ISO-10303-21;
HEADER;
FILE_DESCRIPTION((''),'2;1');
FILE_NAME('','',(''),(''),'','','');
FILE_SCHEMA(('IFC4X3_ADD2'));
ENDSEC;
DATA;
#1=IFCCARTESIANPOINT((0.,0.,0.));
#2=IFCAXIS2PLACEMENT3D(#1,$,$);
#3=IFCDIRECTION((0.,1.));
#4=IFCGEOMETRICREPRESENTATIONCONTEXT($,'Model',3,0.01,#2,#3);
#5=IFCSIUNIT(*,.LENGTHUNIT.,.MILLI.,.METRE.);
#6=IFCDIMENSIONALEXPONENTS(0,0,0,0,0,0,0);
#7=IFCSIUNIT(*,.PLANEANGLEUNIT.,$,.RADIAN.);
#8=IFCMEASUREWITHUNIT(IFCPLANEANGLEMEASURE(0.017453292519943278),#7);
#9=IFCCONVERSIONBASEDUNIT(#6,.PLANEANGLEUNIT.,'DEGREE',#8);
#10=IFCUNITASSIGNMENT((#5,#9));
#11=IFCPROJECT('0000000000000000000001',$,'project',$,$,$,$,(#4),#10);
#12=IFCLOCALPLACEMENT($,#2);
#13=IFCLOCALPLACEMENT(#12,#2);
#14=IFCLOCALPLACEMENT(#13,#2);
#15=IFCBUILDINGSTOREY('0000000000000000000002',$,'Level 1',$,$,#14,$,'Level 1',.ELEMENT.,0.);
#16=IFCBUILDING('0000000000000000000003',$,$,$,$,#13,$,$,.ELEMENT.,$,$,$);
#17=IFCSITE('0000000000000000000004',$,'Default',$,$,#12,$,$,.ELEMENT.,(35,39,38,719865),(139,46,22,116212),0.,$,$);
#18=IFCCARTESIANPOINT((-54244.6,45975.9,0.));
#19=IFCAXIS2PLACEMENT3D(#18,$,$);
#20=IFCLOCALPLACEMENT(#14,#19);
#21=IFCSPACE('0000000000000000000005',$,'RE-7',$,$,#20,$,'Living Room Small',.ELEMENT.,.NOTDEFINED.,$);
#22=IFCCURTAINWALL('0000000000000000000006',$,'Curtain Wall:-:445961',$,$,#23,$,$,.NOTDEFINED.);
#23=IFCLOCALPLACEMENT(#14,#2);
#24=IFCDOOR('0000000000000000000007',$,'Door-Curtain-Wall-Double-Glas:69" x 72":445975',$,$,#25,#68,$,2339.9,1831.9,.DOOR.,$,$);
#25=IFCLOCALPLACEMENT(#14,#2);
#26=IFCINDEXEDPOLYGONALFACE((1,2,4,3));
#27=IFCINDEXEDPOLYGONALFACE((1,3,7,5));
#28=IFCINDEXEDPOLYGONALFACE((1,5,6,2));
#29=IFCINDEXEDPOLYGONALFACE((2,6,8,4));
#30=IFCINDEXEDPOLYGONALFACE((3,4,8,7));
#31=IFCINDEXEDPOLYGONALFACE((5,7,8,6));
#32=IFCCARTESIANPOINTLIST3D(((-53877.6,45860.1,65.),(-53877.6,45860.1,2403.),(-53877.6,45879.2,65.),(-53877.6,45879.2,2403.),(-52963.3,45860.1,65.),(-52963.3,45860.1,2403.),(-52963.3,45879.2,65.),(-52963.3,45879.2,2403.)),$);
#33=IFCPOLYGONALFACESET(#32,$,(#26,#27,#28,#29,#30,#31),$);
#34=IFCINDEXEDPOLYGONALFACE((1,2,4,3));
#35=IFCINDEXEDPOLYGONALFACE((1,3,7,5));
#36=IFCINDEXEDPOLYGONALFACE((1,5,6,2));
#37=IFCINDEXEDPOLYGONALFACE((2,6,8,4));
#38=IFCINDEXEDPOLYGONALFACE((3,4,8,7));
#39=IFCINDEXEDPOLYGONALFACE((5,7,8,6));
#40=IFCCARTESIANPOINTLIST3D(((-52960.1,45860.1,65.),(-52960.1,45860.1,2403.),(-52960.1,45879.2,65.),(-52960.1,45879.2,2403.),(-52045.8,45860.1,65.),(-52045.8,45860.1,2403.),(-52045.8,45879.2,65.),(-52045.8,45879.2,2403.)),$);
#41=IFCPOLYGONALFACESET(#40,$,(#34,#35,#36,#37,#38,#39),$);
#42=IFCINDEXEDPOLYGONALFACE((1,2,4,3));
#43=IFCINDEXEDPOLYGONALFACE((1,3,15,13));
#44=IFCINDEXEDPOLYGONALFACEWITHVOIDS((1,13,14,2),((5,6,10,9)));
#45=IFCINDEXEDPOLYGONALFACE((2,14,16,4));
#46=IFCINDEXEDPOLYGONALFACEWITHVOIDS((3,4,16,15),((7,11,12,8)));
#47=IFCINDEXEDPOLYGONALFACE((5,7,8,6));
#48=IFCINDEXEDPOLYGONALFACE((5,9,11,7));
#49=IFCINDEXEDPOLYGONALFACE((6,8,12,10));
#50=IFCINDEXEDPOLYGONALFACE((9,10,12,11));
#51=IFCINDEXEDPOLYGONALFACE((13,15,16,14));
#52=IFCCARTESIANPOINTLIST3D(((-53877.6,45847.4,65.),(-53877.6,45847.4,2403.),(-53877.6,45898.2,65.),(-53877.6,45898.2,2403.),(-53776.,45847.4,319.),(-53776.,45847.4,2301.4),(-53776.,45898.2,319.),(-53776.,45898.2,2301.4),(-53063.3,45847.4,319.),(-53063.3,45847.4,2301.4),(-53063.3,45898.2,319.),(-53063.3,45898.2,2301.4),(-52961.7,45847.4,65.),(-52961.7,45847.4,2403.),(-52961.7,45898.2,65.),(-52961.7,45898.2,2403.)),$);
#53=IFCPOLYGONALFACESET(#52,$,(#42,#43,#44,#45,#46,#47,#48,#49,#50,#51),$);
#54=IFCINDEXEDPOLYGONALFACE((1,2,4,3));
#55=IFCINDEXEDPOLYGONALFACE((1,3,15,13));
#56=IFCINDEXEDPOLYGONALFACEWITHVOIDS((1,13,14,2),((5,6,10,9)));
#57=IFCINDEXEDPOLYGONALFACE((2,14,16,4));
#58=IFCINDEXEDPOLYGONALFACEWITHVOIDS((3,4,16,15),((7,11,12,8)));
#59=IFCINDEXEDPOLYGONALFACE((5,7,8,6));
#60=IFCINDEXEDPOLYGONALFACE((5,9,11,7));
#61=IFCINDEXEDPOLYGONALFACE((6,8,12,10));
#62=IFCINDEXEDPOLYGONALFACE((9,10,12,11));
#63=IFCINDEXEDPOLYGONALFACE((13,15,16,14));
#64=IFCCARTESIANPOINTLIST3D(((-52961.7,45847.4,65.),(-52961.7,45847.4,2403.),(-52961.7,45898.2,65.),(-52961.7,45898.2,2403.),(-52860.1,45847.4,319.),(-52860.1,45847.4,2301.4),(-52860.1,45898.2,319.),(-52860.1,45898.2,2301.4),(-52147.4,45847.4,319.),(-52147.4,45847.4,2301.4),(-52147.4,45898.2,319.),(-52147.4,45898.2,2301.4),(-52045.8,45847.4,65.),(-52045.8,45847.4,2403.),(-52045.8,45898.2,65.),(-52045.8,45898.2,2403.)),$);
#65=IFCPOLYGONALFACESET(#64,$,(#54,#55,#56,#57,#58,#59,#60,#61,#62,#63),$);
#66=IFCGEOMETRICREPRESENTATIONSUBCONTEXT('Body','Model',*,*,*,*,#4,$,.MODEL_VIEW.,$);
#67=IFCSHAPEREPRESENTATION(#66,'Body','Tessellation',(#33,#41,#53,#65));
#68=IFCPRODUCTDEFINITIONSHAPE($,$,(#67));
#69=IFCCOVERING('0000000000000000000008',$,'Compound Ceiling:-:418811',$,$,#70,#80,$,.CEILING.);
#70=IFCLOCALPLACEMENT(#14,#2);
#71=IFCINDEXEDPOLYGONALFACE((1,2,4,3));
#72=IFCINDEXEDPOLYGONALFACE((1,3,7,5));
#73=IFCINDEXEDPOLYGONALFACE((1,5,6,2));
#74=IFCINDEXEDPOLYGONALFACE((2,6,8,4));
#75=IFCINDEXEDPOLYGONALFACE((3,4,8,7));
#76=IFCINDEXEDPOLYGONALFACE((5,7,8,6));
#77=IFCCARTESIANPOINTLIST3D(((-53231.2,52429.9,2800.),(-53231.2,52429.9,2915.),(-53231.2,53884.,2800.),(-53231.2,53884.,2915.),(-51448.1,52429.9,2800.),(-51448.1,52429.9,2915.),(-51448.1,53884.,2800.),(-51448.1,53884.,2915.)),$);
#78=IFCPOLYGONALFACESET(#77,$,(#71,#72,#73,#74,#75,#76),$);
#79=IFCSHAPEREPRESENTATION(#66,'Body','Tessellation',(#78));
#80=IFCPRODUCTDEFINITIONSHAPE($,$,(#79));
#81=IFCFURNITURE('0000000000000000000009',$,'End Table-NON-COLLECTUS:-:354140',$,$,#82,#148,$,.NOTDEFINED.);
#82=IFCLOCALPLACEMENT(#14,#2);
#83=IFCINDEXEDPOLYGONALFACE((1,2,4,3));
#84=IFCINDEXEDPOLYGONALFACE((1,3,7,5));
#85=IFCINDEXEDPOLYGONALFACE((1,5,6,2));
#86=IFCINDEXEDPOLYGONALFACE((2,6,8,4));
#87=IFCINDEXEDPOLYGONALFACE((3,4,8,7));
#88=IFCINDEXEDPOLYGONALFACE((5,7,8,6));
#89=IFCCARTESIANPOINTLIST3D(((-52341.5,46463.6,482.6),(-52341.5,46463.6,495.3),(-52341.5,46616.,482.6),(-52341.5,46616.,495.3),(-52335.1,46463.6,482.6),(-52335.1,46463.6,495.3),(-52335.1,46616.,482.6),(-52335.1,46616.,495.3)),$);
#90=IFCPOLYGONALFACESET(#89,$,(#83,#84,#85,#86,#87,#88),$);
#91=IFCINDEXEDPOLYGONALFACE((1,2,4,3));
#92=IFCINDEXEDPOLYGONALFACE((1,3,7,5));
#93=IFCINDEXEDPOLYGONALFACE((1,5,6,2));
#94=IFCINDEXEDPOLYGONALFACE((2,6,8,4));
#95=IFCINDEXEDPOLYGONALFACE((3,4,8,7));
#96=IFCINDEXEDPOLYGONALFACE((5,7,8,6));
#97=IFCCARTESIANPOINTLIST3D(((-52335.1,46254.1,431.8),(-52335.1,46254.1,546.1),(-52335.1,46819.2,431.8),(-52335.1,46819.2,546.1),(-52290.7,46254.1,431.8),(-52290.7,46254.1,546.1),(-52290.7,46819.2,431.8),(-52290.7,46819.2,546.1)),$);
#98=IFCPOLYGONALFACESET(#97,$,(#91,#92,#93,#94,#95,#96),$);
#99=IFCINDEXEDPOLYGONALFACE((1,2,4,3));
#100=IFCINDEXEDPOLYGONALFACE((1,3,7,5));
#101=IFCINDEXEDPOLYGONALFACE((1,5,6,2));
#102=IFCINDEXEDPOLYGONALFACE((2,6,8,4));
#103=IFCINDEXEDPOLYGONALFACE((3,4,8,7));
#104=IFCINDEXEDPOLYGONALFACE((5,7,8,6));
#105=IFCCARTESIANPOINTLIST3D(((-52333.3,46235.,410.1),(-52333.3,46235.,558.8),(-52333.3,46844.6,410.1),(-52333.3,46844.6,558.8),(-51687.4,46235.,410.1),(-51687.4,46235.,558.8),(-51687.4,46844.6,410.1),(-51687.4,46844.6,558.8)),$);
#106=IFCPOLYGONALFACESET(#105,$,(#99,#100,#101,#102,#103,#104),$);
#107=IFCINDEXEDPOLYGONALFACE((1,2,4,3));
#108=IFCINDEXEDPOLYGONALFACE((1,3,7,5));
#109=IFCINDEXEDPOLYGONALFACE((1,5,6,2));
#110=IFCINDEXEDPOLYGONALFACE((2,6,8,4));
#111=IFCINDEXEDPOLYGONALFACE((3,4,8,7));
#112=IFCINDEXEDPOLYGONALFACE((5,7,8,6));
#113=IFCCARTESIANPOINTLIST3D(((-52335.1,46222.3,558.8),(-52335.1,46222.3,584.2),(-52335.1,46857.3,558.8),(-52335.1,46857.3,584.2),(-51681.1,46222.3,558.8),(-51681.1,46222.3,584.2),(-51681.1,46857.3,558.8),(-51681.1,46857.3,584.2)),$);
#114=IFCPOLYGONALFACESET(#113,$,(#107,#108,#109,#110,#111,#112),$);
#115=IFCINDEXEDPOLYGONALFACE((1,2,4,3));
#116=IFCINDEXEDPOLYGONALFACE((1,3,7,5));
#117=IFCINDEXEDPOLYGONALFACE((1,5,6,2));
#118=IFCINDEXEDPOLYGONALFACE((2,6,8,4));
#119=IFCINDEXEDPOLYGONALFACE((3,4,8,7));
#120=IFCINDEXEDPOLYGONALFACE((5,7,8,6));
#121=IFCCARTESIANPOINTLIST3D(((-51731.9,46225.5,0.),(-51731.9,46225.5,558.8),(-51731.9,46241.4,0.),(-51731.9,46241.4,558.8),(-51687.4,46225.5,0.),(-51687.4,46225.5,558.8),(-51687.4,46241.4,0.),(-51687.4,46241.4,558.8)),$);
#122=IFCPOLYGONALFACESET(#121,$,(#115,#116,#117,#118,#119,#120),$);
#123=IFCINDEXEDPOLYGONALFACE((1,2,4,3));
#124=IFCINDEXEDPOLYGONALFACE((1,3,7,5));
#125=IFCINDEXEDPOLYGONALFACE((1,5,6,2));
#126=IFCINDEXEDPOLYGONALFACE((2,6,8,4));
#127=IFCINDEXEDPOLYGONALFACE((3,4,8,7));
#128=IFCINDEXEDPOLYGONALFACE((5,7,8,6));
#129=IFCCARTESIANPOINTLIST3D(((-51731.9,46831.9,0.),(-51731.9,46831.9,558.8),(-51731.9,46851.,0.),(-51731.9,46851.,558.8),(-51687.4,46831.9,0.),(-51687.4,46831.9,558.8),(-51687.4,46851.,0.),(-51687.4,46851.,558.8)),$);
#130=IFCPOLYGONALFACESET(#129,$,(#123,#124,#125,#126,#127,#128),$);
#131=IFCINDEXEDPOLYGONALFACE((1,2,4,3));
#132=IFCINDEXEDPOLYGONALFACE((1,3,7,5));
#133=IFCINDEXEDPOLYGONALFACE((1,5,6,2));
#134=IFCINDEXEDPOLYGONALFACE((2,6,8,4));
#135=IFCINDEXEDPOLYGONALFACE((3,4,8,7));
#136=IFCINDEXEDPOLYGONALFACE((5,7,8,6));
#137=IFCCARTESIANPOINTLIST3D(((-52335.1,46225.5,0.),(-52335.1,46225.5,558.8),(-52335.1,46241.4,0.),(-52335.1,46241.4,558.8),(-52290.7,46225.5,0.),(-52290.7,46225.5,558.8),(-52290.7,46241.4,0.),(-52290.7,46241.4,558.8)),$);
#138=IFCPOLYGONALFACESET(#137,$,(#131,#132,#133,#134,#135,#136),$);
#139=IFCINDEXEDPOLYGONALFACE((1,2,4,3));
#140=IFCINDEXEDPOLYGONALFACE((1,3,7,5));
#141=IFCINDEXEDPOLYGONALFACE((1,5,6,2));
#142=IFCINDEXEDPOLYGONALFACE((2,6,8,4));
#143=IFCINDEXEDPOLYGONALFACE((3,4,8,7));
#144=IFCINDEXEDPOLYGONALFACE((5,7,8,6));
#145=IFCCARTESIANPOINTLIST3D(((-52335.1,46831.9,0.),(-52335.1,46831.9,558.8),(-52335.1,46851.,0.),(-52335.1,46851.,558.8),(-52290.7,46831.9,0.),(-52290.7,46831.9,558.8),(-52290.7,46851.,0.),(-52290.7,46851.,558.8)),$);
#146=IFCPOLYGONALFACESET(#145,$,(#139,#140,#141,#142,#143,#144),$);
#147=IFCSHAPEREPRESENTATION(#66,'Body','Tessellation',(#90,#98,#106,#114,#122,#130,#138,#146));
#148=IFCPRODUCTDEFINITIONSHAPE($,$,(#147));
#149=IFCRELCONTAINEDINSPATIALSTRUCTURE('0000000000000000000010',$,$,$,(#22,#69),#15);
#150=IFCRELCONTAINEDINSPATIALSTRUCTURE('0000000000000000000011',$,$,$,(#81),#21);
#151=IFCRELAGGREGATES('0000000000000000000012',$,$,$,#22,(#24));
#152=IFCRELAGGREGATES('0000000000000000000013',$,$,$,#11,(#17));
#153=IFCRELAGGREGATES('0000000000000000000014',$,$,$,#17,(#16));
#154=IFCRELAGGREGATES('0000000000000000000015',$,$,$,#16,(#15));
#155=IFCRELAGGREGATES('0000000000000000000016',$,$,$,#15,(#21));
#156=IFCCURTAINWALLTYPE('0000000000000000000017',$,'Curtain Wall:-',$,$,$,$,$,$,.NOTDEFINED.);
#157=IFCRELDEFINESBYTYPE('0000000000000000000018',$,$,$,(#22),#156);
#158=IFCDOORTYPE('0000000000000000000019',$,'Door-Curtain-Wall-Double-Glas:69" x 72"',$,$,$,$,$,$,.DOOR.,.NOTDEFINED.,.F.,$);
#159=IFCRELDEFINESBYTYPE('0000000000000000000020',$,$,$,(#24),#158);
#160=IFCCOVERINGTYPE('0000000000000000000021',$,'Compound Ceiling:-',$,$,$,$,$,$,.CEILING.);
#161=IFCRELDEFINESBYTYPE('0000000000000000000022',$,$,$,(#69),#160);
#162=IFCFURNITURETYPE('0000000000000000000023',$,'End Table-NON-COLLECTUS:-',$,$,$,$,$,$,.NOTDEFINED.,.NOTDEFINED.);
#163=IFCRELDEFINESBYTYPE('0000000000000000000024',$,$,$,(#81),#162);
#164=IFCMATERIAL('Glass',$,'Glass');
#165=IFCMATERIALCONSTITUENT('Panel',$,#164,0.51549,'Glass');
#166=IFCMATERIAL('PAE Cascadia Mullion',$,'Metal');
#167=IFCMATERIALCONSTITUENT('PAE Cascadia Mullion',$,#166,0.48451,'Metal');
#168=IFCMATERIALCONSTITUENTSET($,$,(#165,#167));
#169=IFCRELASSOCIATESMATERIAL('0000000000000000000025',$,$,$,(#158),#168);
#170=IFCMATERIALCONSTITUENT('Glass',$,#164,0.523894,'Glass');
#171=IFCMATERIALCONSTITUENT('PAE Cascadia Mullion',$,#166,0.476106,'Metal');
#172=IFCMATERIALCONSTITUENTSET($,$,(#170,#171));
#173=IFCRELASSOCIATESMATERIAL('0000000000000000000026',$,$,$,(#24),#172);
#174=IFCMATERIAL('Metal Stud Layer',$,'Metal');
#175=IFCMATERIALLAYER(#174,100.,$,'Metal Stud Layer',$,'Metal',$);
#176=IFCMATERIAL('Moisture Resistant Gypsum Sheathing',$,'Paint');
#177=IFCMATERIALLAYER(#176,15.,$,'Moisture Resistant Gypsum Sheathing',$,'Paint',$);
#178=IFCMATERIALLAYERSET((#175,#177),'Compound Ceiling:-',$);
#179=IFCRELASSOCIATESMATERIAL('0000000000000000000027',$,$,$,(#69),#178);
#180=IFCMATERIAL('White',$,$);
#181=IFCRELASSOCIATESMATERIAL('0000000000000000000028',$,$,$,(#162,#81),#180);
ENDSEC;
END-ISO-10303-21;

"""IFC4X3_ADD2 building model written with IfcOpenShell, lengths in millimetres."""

from ifc_helpers import new_model, entity, si_unit, converted_unit, direction, frame, frame_2d, origin, origin_2d_with_axis, place, context, subcontext, project, spatial, polyline, rectangle, outline, extrude, source, transform, mapped, material, layer, layer_set, layer_usage, constituent, constituent_set, type_object, type_shapes, element, aggregate, save


model = new_model("IFC4X3_ADD2")

# Units and contexts
model_context = context("Model", 3, precision=0.01, world=origin(), true_north=direction((0.0, 1.0)))
body_context = subcontext(model_context, "Body", "Model", "MODEL_VIEW")
ifc_project = project(units=[si_unit("LENGTHUNIT", "METRE", prefix="MILLI"), converted_unit("PLANEANGLEUNIT", "DEGREE", entity("IfcPlaneAngleMeasure", 0.017453292519943278), si_unit("PLANEANGLEUNIT", "RADIAN"), dimensions=[0, 0, 0, 0, 0, 0, 0])], contexts=[model_context])

# Site, building, storey
site_placement = place(None, origin())
site = spatial("IfcSite", under=ifc_project, at=site_placement, Name="Default", CompositionType="ELEMENT", RefLatitude=(35, 39, 38, 719865), RefLongitude=(139, 46, 22, 116212), RefElevation=0.0)
building_placement = place(site_placement, origin())
building = spatial("IfcBuilding", under=site, at=building_placement, CompositionType="ELEMENT")
storey_placement = place(building_placement, origin())
storey = spatial("IfcBuildingStorey", under=building, at=storey_placement, Name="Level 1", LongName="Level 1", CompositionType="ELEMENT", Elevation=0.0)

# Curtain wall
curtain_wall_type = type_object("IfcCurtainWallType", Name="Curtain Wall:-", PredefinedType="NOTDEFINED")
curtain_wall_placement = place(storey_placement, origin())
curtain_wall = element("IfcCurtainWall", 1, at=curtain_wall_placement, inside=storey, type_object=curtain_wall_type, Name="Curtain Wall:-:445961", PredefinedType="NOTDEFINED")

# Shared definitions
ifc_material_1 = material(Name="Glass", Category="Glass")

# Shared definitions
ifc_material_2 = material(Name="Metal Stud Layer", Category="Metal")

# Door
ifc_constituent_1 = constituent(ifc_material_1, Name="Glass", Category="Glass", fraction=0.523894)
ifc_material_3 = material(Name="PAE Cascadia Mullion", Category="Metal")
ifc_constituent_2 = constituent(ifc_material_3, Name="PAE Cascadia Mullion", Category="Metal", fraction=0.476106)
ifc_constituent_set_1 = constituent_set(constituents=[ifc_constituent_1, ifc_constituent_2])
ifc_constituent_3 = constituent(ifc_material_1, Name="Panel", Category="Glass", fraction=0.51549)
ifc_constituent_4 = constituent(ifc_material_3, Name="PAE Cascadia Mullion", Category="Metal", fraction=0.48451)
ifc_constituent_set_2 = constituent_set(constituents=[ifc_constituent_3, ifc_constituent_4])
door_type_1 = type_object("IfcDoorType", Name="Door-Curtain-Wall-Double-Glas:69\" x 72\"", OperationType="NOTDEFINED", ParameterTakesPrecedence=False, PredefinedType="DOOR", material=ifc_constituent_set_2)
shared_shape_1 = source(origin(), body_context, "Body", "SweptSolid", [
    extrude(rectangle(XDim=19.1, YDim=914.4, at=frame_2d((0.0, 0.0), x_axis=(1.0, 0.0))), frame((458.7, 41.3, 0.0), z_axis=(0.0, 0.0, 1.0), x_axis=(0.0, 1.0, 0.0)), (0.0, 0.0, 1.0), 2338.0),
    extrude(rectangle(XDim=19.1, YDim=914.3, at=frame_2d((0.0, 0.0), x_axis=(1.0, 0.0))), frame((-458.8, 41.3, 0.0), z_axis=(0.0, 0.0, 1.0), x_axis=(0.0, 1.0, 0.0)), (0.0, 0.0, 1.0), 2338.0),
    extrude(outline(polyline([(-458.0, -1169.0), (458.0, -1169.0), (458.0, 1169.0), (-458.0, 1169.0), (-458.0, -1169.0)]), holes=[polyline([(-356.4, -1067.4), (-356.4, 915.0), (356.4, 915.0), (356.4, -1067.4), (-356.4, -1067.4)])]), frame((458.0, 12.7, 1169.0), z_axis=(0.0, 1.0, 0.0), x_axis=(1.0, 0.0, 0.0)), (0.0, 0.0, 1.0), 50.8),
    extrude(outline(polyline([(-1169.0, -458.0), (1169.0, -458.0), (1169.0, 458.0), (-1169.0, 458.0), (-1169.0, -458.0)]), holes=[polyline([(-1067.4, -356.4), (-1067.4, 356.4), (915.0, 356.4), (915.0, -356.4), (-1067.4, -356.4)])]), frame((-458.0, 12.7, 1169.0), z_axis=(0.0, 1.0, 0.0), x_axis=(0.0, 0.0, -1.0)), (0.0, 0.0, 1.0), 50.8),
])
type_shapes(door_type_1, [shared_shape_1])
door_1_placement = place(curtain_wall_placement, frame((-52961.7, 45910.9, 65.0), z_axis=(0.0, 0.0, 1.0), x_axis=(-1.0, 0.0, 0.0)))
door_1 = element("IfcDoor", 2, at=door_1_placement, type_object=door_type_1, material=ifc_constituent_set_1, Name="Door-Curtain-Wall-Double-Glas:69\" x 72\":445975", OverallHeight=2339.9, OverallWidth=1831.9, PredefinedType="DOOR", context=body_context, shape_type="MappedRepresentation", body=[
    mapped(shared_shape_1, transform((0.0, 0.0, 0.0), scale=1.0)),
])
aggregate(curtain_wall, [door_1])

# Covering
ifc_layer_1 = layer(ifc_material_2, 100.0, Name="Metal Stud Layer", Category="Metal")
ifc_material_4 = material(Name="Moisture Resistant Gypsum Sheathing", Category="Paint")
ifc_layer_2 = layer(ifc_material_4, 15.0, Name="Moisture Resistant Gypsum Sheathing", Category="Paint")
ifc_layer_set_1 = layer_set([ifc_layer_1, ifc_layer_2], Name="Compound Ceiling:-")
ifc_layer_usage_1 = layer_usage(ifc_layer_set_1, "AXIS3", "NEGATIVE", 0.0)
covering_type = type_object("IfcCoveringType", Name="Compound Ceiling:-", PredefinedType="CEILING")
covering_placement = place(storey_placement, frame((-53231.2, 52429.9, 2800.0)))
element("IfcCovering", 3, at=covering_placement, inside=storey, type_object=covering_type, material=ifc_layer_usage_1, Name="Compound Ceiling:-:418811", PredefinedType="CEILING", context=body_context, shape_type="SweptSolid", body=[
    extrude(rectangle(XDim=1783.1, YDim=1454.2, at=frame_2d((0.0, 0.0), x_axis=(1.0, 0.0))), frame((891.5, 727.1, 0.0)), (0.0, 0.0, 1.0), 115.0),
])

# Shared definitions
space_1_placement = place(storey_placement, frame((-54244.6, 45975.9, 0.0)))
space_1 = spatial("IfcSpace", under=storey, at=space_1_placement, Name="RE-7", LongName="Living Room Small", CompositionType="ELEMENT", PredefinedType="NOTDEFINED")

# Furniture
ifc_material_5 = material(Name="White")
furniture_type_1 = type_object("IfcFurnitureType", Name="End Table-NON-COLLECTUS:-", AssemblyPlace="NOTDEFINED", PredefinedType="NOTDEFINED", material=ifc_material_5)
shared_shape_2 = source(origin(), body_context, "Body", "SweptSolid", [
    extrude(rectangle(XDim=6.4, YDim=152.4, at=origin_2d_with_axis()), frame((0.0, -657.2, 482.6), z_axis=(0.0, 0.0, 1.0), x_axis=(0.0, 1.0, 0.0)), (0.0, 0.0, 1.0), 12.7),
    extrude(rectangle(XDim=44.4, YDim=565.2, at=origin_2d_with_axis()), frame((3.2, -631.8, 431.8), z_axis=(0.0, 0.0, 1.0), x_axis=(0.0, 1.0, 0.0)), (0.0, 0.0, 1.0), 114.3),
    extrude(rectangle(XDim=609.6, YDim=645.8, at=frame_2d((0.0, 0.0), x_axis=(1.0, 0.0))), frame((0.0, -329.3, 410.1), z_axis=(0.0, 0.0, 1.0), x_axis=(-1.0, 0.0, 0.0)), (0.0, 0.0, 1.0), 148.7),
    extrude(rectangle(XDim=635.0, YDim=654.0, at=frame_2d((0.0, 0.0), x_axis=(1.0, 0.0))), frame((0.0, -327.0, 558.8), z_axis=(0.0, 0.0, 1.0), x_axis=(-1.0, 0.0, 0.0)), (0.0, 0.0, 1.0), 25.4),
    extrude(rectangle(XDim=15.8, YDim=44.4, at=origin_2d_with_axis()), frame((306.4, -28.6, 0.0), z_axis=(0.0, 0.0, 1.0), x_axis=(-1.0, 0.0, 0.0)), (0.0, 0.0, 1.0), 558.8),
    extrude(rectangle(XDim=19.1, YDim=44.5, at=origin_2d_with_axis()), frame((-301.6, -28.6, 0.0), z_axis=(0.0, 0.0, 1.0), x_axis=(-1.0, 0.0, 0.0)), (0.0, 0.0, 1.0), 558.8),
    extrude(rectangle(XDim=15.8, YDim=44.4, at=origin_2d_with_axis()), frame((306.4, -631.8, 0.0), z_axis=(0.0, 0.0, 1.0), x_axis=(-1.0, 0.0, 0.0)), (0.0, 0.0, 1.0), 558.8),
    extrude(rectangle(XDim=19.1, YDim=44.4, at=frame_2d((0.0, 0.0), x_axis=(1.0, 0.0))), frame((-301.6, -631.8, 0.0), z_axis=(0.0, 0.0, 1.0), x_axis=(-1.0, 0.0, 0.0)), (0.0, 0.0, 1.0), 558.8),
])
type_shapes(furniture_type_1, [shared_shape_2])
furniture_1_placement = place(space_1_placement, frame((2563.5, 563.9, 0.0), z_axis=(0.0, 0.0, 1.0), x_axis=(-0.000004, -1.0, 0.0)))
element("IfcFurniture", 4, at=furniture_1_placement, inside=space_1, type_object=furniture_type_1, material=ifc_material_5, Name="End Table-NON-COLLECTUS:-:354140", PredefinedType="NOTDEFINED", context=body_context, shape_type="MappedRepresentation", body=[
    mapped(shared_shape_2, transform((0.0, 0.0, 0.0), scale=1.0)),
])

save(model, "model.ifc")
